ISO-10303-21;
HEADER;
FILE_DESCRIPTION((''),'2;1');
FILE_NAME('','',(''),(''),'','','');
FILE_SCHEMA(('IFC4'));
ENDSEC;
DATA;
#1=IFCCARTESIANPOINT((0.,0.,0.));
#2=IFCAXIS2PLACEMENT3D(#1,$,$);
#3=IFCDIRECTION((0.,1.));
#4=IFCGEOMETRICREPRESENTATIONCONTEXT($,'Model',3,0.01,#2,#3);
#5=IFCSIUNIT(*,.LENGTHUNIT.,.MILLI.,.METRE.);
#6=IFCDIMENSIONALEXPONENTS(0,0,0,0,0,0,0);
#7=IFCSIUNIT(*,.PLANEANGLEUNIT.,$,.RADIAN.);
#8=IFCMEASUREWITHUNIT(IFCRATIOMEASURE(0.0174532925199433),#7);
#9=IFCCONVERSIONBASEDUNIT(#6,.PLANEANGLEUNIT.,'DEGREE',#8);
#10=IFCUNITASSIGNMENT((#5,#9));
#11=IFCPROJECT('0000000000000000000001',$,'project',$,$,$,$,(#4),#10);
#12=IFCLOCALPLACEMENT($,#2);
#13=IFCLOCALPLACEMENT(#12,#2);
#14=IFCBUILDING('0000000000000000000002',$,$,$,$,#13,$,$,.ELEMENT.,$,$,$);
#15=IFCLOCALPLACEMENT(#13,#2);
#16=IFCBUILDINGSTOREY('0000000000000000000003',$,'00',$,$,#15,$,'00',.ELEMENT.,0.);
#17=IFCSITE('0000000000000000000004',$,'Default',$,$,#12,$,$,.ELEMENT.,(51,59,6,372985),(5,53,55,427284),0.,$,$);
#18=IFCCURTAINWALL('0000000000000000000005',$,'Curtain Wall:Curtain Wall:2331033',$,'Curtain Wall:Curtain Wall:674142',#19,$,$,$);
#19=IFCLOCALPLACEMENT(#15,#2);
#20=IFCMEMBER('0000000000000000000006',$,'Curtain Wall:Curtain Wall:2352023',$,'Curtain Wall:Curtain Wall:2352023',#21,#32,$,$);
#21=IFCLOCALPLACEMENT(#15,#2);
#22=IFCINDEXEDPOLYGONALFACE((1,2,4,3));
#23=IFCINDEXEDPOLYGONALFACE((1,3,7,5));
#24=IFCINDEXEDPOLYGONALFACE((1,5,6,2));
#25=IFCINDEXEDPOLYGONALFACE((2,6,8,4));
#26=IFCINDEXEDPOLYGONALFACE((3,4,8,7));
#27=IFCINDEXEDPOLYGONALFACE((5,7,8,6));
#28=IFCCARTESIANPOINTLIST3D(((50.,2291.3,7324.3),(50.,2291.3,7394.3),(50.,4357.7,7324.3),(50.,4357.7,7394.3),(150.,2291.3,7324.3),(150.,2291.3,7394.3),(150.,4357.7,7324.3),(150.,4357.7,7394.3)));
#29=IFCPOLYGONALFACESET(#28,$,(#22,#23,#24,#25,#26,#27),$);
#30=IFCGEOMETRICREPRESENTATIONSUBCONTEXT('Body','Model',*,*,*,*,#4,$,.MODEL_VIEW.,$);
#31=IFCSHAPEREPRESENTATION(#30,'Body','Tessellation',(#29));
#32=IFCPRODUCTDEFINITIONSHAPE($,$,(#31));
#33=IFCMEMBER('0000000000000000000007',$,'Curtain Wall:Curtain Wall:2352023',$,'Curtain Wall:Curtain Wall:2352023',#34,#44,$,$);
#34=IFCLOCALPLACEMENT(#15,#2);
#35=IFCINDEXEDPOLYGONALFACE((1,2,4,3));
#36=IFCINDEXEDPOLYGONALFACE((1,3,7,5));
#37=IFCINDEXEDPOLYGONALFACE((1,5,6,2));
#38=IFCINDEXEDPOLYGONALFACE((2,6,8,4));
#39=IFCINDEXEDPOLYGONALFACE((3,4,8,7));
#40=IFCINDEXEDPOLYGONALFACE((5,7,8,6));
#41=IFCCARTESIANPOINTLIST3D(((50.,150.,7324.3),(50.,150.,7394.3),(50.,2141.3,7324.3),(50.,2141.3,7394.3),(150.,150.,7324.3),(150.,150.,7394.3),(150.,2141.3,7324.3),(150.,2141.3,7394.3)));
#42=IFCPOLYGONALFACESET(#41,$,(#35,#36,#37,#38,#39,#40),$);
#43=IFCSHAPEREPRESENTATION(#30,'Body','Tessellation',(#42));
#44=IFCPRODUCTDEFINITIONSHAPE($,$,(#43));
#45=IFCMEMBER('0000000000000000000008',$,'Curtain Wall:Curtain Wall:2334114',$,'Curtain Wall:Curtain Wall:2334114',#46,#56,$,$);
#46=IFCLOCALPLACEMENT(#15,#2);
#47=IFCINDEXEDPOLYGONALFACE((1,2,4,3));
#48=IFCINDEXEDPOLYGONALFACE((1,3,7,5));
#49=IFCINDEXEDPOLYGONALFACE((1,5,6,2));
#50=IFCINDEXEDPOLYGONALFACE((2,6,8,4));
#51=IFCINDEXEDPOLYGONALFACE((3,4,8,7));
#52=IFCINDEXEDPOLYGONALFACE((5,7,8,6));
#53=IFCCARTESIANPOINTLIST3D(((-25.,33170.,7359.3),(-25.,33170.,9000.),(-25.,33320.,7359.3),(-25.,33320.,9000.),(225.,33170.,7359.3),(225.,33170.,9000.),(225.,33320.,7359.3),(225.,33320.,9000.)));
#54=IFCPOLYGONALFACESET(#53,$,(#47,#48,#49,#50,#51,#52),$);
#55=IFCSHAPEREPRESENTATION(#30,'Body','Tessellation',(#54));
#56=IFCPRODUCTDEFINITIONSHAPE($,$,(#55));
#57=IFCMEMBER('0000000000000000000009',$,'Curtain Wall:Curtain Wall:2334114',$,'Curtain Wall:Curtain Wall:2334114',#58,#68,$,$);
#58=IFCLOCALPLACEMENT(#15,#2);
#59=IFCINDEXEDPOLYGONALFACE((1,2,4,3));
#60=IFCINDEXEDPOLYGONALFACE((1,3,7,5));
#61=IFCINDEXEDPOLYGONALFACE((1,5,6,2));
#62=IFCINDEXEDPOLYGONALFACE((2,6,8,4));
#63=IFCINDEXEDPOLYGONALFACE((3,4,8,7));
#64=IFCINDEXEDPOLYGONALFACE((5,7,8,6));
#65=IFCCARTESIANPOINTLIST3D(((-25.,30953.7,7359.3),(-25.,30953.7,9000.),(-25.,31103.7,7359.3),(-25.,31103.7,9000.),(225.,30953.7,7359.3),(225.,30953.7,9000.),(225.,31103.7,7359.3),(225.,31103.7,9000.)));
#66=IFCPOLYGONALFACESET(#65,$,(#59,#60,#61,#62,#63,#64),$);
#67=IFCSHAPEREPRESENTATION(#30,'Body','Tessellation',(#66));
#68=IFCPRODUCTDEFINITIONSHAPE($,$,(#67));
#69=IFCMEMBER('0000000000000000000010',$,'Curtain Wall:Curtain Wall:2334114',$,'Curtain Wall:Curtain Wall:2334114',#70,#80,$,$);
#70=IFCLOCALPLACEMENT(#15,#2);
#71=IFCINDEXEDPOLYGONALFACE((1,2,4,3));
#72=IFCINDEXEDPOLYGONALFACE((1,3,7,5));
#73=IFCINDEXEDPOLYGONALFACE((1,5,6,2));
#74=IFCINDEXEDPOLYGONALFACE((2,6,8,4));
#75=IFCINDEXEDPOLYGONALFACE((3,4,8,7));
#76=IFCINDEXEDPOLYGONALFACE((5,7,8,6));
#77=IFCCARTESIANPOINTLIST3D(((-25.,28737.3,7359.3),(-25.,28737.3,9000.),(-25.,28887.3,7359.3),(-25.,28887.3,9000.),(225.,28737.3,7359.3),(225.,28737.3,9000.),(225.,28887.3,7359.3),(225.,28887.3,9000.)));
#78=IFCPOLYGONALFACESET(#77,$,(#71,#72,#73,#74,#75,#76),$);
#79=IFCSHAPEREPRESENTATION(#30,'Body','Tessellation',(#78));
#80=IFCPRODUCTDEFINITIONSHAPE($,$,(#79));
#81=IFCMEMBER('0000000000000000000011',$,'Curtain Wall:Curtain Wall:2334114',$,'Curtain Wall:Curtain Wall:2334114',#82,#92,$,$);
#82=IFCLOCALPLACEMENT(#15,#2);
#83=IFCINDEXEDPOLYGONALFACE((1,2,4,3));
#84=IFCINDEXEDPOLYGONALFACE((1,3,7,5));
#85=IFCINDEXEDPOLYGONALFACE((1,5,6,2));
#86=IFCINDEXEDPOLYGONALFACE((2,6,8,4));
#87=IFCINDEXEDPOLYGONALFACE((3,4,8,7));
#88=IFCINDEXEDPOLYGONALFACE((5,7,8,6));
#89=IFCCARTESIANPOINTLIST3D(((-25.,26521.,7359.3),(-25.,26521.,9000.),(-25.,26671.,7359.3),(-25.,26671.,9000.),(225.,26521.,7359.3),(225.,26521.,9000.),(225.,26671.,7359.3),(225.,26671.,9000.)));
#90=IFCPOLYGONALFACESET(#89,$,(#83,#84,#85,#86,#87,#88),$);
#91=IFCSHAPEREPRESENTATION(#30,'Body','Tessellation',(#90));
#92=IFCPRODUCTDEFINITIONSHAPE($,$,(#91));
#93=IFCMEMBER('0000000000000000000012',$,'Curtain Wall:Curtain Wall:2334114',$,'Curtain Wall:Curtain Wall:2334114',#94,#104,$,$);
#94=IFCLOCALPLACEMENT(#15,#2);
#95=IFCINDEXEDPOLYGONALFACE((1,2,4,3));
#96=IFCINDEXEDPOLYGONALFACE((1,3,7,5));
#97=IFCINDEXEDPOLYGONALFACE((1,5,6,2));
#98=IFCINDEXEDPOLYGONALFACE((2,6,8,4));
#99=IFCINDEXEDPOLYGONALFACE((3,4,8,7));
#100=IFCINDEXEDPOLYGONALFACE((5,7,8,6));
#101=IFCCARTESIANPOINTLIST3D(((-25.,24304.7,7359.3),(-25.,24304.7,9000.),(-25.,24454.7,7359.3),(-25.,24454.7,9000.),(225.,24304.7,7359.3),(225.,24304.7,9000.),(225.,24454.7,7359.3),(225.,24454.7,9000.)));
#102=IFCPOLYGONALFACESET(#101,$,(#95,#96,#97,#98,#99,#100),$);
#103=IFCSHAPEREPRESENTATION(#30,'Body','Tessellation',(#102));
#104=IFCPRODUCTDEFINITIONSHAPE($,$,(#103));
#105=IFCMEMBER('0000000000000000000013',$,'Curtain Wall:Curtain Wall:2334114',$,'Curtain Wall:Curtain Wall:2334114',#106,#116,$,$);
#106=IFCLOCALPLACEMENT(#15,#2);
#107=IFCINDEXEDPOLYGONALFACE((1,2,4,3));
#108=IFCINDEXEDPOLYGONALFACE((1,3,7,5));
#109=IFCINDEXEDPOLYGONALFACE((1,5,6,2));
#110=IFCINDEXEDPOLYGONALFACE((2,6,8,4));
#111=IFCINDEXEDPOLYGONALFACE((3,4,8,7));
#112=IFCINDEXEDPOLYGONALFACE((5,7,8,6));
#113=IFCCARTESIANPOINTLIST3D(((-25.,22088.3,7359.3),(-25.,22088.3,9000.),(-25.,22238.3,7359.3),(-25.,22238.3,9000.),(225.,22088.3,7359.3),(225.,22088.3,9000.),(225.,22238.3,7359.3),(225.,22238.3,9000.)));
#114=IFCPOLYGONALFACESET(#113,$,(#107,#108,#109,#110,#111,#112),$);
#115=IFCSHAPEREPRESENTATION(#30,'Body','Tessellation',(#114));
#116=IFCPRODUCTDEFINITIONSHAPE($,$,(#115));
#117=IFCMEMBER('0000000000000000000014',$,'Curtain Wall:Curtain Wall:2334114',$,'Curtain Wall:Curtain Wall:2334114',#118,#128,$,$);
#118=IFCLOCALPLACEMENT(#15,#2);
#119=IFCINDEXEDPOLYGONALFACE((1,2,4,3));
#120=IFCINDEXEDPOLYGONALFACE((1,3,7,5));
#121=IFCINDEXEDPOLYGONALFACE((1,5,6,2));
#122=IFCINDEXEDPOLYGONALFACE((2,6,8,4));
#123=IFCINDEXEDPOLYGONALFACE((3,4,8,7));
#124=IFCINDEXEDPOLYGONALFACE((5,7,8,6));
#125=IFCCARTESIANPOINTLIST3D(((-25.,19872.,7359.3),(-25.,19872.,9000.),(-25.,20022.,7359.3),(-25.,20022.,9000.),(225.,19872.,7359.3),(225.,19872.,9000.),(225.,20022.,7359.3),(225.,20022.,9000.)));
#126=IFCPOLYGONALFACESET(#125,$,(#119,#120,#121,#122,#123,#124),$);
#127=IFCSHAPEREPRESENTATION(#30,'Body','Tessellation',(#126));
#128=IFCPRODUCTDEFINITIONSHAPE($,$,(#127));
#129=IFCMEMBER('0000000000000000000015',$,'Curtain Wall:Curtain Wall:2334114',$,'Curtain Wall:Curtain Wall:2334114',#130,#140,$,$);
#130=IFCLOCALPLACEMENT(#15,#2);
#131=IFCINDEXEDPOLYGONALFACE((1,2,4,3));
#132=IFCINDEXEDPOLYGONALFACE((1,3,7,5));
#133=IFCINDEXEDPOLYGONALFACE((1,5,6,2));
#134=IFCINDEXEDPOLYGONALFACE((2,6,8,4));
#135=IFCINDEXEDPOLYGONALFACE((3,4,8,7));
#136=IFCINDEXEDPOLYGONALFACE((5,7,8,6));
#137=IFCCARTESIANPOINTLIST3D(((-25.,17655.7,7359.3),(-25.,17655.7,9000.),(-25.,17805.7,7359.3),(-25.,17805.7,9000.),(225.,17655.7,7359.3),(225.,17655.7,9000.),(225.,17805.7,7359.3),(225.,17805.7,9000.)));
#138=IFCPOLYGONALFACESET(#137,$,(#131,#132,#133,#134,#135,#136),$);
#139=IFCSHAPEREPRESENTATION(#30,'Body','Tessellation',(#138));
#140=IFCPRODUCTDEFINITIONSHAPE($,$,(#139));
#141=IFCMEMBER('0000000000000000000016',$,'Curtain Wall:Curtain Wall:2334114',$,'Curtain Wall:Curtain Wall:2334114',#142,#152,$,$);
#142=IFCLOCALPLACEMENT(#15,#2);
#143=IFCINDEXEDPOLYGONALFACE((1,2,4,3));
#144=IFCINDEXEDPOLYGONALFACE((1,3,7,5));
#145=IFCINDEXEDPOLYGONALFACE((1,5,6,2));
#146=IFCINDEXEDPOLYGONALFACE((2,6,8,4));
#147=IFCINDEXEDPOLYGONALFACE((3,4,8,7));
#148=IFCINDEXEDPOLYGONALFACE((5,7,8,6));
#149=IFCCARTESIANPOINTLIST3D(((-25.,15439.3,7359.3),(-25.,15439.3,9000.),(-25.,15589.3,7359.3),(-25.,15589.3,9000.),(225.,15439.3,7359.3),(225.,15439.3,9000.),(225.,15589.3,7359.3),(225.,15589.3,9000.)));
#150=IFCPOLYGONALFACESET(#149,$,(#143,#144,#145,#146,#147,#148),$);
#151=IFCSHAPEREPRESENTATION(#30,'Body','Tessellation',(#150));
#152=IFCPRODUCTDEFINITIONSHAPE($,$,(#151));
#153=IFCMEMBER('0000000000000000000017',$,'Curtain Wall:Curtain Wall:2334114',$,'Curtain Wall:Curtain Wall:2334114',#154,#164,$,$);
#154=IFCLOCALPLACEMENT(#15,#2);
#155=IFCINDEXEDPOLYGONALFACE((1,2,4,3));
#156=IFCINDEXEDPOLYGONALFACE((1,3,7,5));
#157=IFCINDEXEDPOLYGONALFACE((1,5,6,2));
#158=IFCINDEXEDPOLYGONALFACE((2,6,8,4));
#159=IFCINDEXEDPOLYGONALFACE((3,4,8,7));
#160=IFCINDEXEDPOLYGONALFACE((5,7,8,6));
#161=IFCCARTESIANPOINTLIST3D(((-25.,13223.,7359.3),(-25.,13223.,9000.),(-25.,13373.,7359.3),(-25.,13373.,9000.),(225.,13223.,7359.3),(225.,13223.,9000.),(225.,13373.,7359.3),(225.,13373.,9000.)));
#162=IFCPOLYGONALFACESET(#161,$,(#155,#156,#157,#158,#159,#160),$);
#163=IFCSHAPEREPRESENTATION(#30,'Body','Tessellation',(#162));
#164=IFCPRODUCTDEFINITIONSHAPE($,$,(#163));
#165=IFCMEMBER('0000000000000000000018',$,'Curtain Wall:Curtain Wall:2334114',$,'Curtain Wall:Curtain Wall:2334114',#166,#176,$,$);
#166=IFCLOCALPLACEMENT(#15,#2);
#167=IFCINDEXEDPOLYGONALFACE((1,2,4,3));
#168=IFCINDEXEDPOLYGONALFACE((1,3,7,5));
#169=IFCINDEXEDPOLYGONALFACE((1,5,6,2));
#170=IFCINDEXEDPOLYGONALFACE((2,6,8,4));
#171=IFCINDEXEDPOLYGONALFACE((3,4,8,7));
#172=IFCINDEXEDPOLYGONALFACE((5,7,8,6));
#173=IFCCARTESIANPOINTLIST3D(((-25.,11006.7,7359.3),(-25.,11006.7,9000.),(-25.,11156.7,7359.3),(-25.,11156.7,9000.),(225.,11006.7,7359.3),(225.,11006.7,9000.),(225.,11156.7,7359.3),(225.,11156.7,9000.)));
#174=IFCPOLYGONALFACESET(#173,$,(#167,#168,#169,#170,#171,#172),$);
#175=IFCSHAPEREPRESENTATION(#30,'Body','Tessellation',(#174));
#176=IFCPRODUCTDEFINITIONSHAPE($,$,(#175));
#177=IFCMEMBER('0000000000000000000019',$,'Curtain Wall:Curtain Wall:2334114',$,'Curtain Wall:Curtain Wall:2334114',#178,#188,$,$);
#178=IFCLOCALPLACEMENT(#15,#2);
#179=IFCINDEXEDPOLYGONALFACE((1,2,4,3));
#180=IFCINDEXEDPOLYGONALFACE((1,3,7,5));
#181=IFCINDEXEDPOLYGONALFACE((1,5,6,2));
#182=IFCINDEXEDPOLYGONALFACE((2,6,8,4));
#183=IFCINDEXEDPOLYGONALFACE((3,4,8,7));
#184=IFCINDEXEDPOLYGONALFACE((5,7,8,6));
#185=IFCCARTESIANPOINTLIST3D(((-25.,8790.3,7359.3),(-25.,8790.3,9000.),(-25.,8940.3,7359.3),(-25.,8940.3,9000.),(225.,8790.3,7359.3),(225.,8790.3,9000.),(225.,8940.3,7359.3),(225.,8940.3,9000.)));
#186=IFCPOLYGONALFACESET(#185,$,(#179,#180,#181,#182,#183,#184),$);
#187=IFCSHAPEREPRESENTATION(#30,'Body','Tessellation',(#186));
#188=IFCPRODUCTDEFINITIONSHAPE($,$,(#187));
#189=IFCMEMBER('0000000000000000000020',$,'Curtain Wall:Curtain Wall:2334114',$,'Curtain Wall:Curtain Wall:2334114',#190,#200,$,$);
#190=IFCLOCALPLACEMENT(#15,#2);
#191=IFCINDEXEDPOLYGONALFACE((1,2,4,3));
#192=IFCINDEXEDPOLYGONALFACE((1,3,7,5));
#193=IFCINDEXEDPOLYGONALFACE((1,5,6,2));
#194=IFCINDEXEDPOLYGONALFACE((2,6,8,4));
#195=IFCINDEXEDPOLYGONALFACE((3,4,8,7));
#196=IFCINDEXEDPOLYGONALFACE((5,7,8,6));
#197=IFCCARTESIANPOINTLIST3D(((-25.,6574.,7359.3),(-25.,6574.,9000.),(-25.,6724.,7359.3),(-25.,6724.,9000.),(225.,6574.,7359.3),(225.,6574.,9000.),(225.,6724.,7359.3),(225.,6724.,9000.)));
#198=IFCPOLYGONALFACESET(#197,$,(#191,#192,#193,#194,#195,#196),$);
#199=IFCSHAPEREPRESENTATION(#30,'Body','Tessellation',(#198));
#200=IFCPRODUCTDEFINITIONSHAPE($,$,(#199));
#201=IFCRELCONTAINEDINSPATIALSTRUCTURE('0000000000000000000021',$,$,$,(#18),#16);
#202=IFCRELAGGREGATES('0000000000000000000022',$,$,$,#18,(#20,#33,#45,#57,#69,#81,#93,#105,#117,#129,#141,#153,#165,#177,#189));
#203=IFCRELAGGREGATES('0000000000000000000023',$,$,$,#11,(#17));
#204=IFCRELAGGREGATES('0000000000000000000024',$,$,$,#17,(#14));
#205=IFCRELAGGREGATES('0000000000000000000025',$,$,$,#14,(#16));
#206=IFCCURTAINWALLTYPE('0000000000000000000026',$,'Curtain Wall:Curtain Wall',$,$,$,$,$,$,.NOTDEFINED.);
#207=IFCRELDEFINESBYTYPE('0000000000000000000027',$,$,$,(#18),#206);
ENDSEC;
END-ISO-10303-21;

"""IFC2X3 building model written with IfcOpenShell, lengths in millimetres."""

from ifc_helpers import new_model, entity, si_unit, converted_unit, direction, frame, frame_2d, origin, origin_2d_with_axis, place, context, subcontext, project, spatial, rectangle, extrude, type_object, element, aggregate, save


model = new_model("IFC2X3")

# Units and contexts
model_context = context("Model", 3, precision=0.01, world=origin(), true_north=direction((0.0, 1.0)))
body_context = subcontext(model_context, "Body", "Model", "MODEL_VIEW")
ifc_project = project(units=[si_unit("LENGTHUNIT", "METRE", prefix="MILLI"), converted_unit("PLANEANGLEUNIT", "DEGREE", entity("IfcRatioMeasure", 0.0174532925199433), si_unit("PLANEANGLEUNIT", "RADIAN"), dimensions=[0, 0, 0, 0, 0, 0, 0])], contexts=[model_context])

# Site, building, storey
site_placement = place(None, origin())
site = spatial("IfcSite", under=ifc_project, at=site_placement, Name="Default", CompositionType="ELEMENT", RefLatitude=(51, 59, 6, 372985), RefLongitude=(5, 53, 55, 427284), RefElevation=0.0)
building_placement = place(site_placement, origin())
building = spatial("IfcBuilding", under=site, at=building_placement, CompositionType="ELEMENT")
storey_placement = place(building_placement, origin())
storey = spatial("IfcBuildingStorey", under=building, at=storey_placement, Name="00", LongName="00", CompositionType="ELEMENT", Elevation=0.0)

# Curtain wall, members
curtain_wall_type = type_object("IfcCurtainWallType", Name="Curtain Wall:Curtain Wall", PredefinedType="NOTDEFINED")
curtain_wall_1_placement = place(storey_placement, origin())
curtain_wall_1 = element("IfcCurtainWall", 1, at=curtain_wall_1_placement, inside=storey, type_object=curtain_wall_type, Name="Curtain Wall:Curtain Wall:2331033", ObjectType="Curtain Wall:Curtain Wall:674142")
member_1_placement = place(curtain_wall_1_placement, origin())
member_1 = element("IfcMember", 2, at=member_1_placement, Name="Curtain Wall:Curtain Wall:2352023", ObjectType="Curtain Wall:Curtain Wall:2352023", context=body_context, shape_type="SweptSolid", body=[
    extrude(rectangle(XDim=70.0, YDim=100.0, at=frame_2d((0.0, 0.0), x_axis=(1.0, 0.0))), frame((100.0, 2291.3, 7359.3), z_axis=(0.0, 1.0, 0.0), x_axis=(0.0, 0.0, -1.0)), (0.0, 0.0, 1.0), 2066.3),
])
member_2_placement = place(curtain_wall_1_placement, origin())
member_2 = element("IfcMember", 3, at=member_2_placement, Name="Curtain Wall:Curtain Wall:2352023", ObjectType="Curtain Wall:Curtain Wall:2352023", context=body_context, shape_type="SweptSolid", body=[
    extrude(rectangle(XDim=70.0, YDim=100.0, at=frame_2d((0.0, 0.0), x_axis=(1.0, 0.0))), frame((100.0, 150.0, 7359.3), z_axis=(0.0, 1.0, 0.0), x_axis=(0.0, 0.0, -1.0)), (0.0, 0.0, 1.0), 1991.3),
])
member_3_placement = place(curtain_wall_1_placement, origin())
member_3 = element("IfcMember", 4, at=member_3_placement, Name="Curtain Wall:Curtain Wall:2334114", ObjectType="Curtain Wall:Curtain Wall:2334114", context=body_context, shape_type="SweptSolid", body=[
    extrude(rectangle(XDim=250.0, YDim=150.0, at=origin_2d_with_axis()), frame((100.0, 33245.0, 7359.3), z_axis=(0.0, 0.0, 1.0), x_axis=(-1.0, 0.0, 0.0)), (0.0, 0.0, 1.0), 1640.7),
])
member_4_placement = place(curtain_wall_1_placement, origin())
member_4 = element("IfcMember", 5, at=member_4_placement, Name="Curtain Wall:Curtain Wall:2334114", ObjectType="Curtain Wall:Curtain Wall:2334114", context=body_context, shape_type="SweptSolid", body=[
    extrude(rectangle(XDim=250.0, YDim=150.0, at=frame_2d((0.0, 0.0), x_axis=(1.0, 0.0))), frame((100.0, 31028.7, 7359.3), z_axis=(0.0, 0.0, 1.0), x_axis=(-1.0, 0.0, 0.0)), (0.0, 0.0, 1.0), 1640.7),
])
member_5_placement = place(curtain_wall_1_placement, origin())
member_5 = element("IfcMember", 6, at=member_5_placement, Name="Curtain Wall:Curtain Wall:2334114", ObjectType="Curtain Wall:Curtain Wall:2334114", context=body_context, shape_type="SweptSolid", body=[
    extrude(rectangle(XDim=250.0, YDim=150.0, at=frame_2d((0.0, 0.0), x_axis=(1.0, 0.0))), frame((100.0, 28812.3, 7359.3), z_axis=(0.0, 0.0, 1.0), x_axis=(-1.0, 0.0, 0.0)), (0.0, 0.0, 1.0), 1640.7),
])
member_6_placement = place(curtain_wall_1_placement, origin())
member_6 = element("IfcMember", 7, at=member_6_placement, Name="Curtain Wall:Curtain Wall:2334114", ObjectType="Curtain Wall:Curtain Wall:2334114", context=body_context, shape_type="SweptSolid", body=[
    extrude(rectangle(XDim=250.0, YDim=150.0, at=frame_2d((0.0, 0.0), x_axis=(1.0, 0.0))), frame((100.0, 26596.0, 7359.3), z_axis=(0.0, 0.0, 1.0), x_axis=(-1.0, 0.0, 0.0)), (0.0, 0.0, 1.0), 1640.7),
])
member_7_placement = place(curtain_wall_1_placement, origin())
member_7 = element("IfcMember", 8, at=member_7_placement, Name="Curtain Wall:Curtain Wall:2334114", ObjectType="Curtain Wall:Curtain Wall:2334114", context=body_context, shape_type="SweptSolid", body=[
    extrude(rectangle(XDim=250.0, YDim=150.0, at=origin_2d_with_axis()), frame((100.0, 24379.7, 7359.3), z_axis=(0.0, 0.0, 1.0), x_axis=(-1.0, 0.0, 0.0)), (0.0, 0.0, 1.0), 1640.7),
])
member_8_placement = place(curtain_wall_1_placement, origin())
member_8 = element("IfcMember", 9, at=member_8_placement, Name="Curtain Wall:Curtain Wall:2334114", ObjectType="Curtain Wall:Curtain Wall:2334114", context=body_context, shape_type="SweptSolid", body=[
    extrude(rectangle(XDim=250.0, YDim=150.0, at=origin_2d_with_axis()), frame((100.0, 22163.3, 7359.3), z_axis=(0.0, 0.0, 1.0), x_axis=(-1.0, 0.0, 0.0)), (0.0, 0.0, 1.0), 1640.7),
])
member_9_placement = place(curtain_wall_1_placement, origin())
member_9 = element("IfcMember", 10, at=member_9_placement, Name="Curtain Wall:Curtain Wall:2334114", ObjectType="Curtain Wall:Curtain Wall:2334114", context=body_context, shape_type="SweptSolid", body=[
    extrude(rectangle(XDim=250.0, YDim=150.0, at=frame_2d((0.0, 0.0), x_axis=(1.0, 0.0))), frame((100.0, 19947.0, 7359.3), z_axis=(0.0, 0.0, 1.0), x_axis=(-1.0, 0.0, 0.0)), (0.0, 0.0, 1.0), 1640.7),
])
member_10_placement = place(curtain_wall_1_placement, origin())
member_10 = element("IfcMember", 11, at=member_10_placement, Name="Curtain Wall:Curtain Wall:2334114", ObjectType="Curtain Wall:Curtain Wall:2334114", context=body_context, shape_type="SweptSolid", body=[
    extrude(rectangle(XDim=250.0, YDim=150.0, at=frame_2d((0.0, 0.0), x_axis=(1.0, 0.0))), frame((100.0, 17730.7, 7359.3), z_axis=(0.0, 0.0, 1.0), x_axis=(-1.0, 0.0, 0.0)), (0.0, 0.0, 1.0), 1640.7),
])
member_11_placement = place(curtain_wall_1_placement, origin())
member_11 = element("IfcMember", 12, at=member_11_placement, Name="Curtain Wall:Curtain Wall:2334114", ObjectType="Curtain Wall:Curtain Wall:2334114", context=body_context, shape_type="SweptSolid", body=[
    extrude(rectangle(XDim=250.0, YDim=150.0, at=frame_2d((0.0, 0.0), x_axis=(1.0, 0.0))), frame((100.0, 15514.3, 7359.3), z_axis=(0.0, 0.0, 1.0), x_axis=(-1.0, 0.0, 0.0)), (0.0, 0.0, 1.0), 1640.7),
])
member_12_placement = place(curtain_wall_1_placement, origin())
member_12 = element("IfcMember", 13, at=member_12_placement, Name="Curtain Wall:Curtain Wall:2334114", ObjectType="Curtain Wall:Curtain Wall:2334114", context=body_context, shape_type="SweptSolid", body=[
    extrude(rectangle(XDim=250.0, YDim=150.0, at=origin_2d_with_axis()), frame((100.0, 13298.0, 7359.3), z_axis=(0.0, 0.0, 1.0), x_axis=(-1.0, 0.0, 0.0)), (0.0, 0.0, 1.0), 1640.7),
])
member_13_placement = place(curtain_wall_1_placement, origin())
member_13 = element("IfcMember", 14, at=member_13_placement, Name="Curtain Wall:Curtain Wall:2334114", ObjectType="Curtain Wall:Curtain Wall:2334114", context=body_context, shape_type="SweptSolid", body=[
    extrude(rectangle(XDim=250.0, YDim=150.0, at=origin_2d_with_axis()), frame((100.0, 11081.7, 7359.3), z_axis=(0.0, 0.0, 1.0), x_axis=(-1.0, 0.0, 0.0)), (0.0, 0.0, 1.0), 1640.7),
])
member_14_placement = place(curtain_wall_1_placement, origin())
member_14 = element("IfcMember", 15, at=member_14_placement, Name="Curtain Wall:Curtain Wall:2334114", ObjectType="Curtain Wall:Curtain Wall:2334114", context=body_context, shape_type="SweptSolid", body=[
    extrude(rectangle(XDim=250.0, YDim=150.0, at=frame_2d((0.0, 0.0), x_axis=(1.0, 0.0))), frame((100.0, 8865.3, 7359.3), z_axis=(0.0, 0.0, 1.0), x_axis=(-1.0, 0.0, 0.0)), (0.0, 0.0, 1.0), 1640.7),
])
member_15_placement = place(curtain_wall_1_placement, origin())
member_15 = element("IfcMember", 16, at=member_15_placement, Name="Curtain Wall:Curtain Wall:2334114", ObjectType="Curtain Wall:Curtain Wall:2334114", context=body_context, shape_type="SweptSolid", body=[
    extrude(rectangle(XDim=250.0, YDim=150.0, at=frame_2d((0.0, 0.0), x_axis=(1.0, 0.0))), frame((100.0, 6649.0, 7359.3), z_axis=(0.0, 0.0, 1.0), x_axis=(-1.0, 0.0, 0.0)), (0.0, 0.0, 1.0), 1640.7),
])
aggregate(curtain_wall_1, [member_1, member_2, member_3, member_4, member_5, member_6, member_7, member_8, member_9, member_10, member_11, member_12, member_13, member_14, member_15])

save(model, "model.ifc")
